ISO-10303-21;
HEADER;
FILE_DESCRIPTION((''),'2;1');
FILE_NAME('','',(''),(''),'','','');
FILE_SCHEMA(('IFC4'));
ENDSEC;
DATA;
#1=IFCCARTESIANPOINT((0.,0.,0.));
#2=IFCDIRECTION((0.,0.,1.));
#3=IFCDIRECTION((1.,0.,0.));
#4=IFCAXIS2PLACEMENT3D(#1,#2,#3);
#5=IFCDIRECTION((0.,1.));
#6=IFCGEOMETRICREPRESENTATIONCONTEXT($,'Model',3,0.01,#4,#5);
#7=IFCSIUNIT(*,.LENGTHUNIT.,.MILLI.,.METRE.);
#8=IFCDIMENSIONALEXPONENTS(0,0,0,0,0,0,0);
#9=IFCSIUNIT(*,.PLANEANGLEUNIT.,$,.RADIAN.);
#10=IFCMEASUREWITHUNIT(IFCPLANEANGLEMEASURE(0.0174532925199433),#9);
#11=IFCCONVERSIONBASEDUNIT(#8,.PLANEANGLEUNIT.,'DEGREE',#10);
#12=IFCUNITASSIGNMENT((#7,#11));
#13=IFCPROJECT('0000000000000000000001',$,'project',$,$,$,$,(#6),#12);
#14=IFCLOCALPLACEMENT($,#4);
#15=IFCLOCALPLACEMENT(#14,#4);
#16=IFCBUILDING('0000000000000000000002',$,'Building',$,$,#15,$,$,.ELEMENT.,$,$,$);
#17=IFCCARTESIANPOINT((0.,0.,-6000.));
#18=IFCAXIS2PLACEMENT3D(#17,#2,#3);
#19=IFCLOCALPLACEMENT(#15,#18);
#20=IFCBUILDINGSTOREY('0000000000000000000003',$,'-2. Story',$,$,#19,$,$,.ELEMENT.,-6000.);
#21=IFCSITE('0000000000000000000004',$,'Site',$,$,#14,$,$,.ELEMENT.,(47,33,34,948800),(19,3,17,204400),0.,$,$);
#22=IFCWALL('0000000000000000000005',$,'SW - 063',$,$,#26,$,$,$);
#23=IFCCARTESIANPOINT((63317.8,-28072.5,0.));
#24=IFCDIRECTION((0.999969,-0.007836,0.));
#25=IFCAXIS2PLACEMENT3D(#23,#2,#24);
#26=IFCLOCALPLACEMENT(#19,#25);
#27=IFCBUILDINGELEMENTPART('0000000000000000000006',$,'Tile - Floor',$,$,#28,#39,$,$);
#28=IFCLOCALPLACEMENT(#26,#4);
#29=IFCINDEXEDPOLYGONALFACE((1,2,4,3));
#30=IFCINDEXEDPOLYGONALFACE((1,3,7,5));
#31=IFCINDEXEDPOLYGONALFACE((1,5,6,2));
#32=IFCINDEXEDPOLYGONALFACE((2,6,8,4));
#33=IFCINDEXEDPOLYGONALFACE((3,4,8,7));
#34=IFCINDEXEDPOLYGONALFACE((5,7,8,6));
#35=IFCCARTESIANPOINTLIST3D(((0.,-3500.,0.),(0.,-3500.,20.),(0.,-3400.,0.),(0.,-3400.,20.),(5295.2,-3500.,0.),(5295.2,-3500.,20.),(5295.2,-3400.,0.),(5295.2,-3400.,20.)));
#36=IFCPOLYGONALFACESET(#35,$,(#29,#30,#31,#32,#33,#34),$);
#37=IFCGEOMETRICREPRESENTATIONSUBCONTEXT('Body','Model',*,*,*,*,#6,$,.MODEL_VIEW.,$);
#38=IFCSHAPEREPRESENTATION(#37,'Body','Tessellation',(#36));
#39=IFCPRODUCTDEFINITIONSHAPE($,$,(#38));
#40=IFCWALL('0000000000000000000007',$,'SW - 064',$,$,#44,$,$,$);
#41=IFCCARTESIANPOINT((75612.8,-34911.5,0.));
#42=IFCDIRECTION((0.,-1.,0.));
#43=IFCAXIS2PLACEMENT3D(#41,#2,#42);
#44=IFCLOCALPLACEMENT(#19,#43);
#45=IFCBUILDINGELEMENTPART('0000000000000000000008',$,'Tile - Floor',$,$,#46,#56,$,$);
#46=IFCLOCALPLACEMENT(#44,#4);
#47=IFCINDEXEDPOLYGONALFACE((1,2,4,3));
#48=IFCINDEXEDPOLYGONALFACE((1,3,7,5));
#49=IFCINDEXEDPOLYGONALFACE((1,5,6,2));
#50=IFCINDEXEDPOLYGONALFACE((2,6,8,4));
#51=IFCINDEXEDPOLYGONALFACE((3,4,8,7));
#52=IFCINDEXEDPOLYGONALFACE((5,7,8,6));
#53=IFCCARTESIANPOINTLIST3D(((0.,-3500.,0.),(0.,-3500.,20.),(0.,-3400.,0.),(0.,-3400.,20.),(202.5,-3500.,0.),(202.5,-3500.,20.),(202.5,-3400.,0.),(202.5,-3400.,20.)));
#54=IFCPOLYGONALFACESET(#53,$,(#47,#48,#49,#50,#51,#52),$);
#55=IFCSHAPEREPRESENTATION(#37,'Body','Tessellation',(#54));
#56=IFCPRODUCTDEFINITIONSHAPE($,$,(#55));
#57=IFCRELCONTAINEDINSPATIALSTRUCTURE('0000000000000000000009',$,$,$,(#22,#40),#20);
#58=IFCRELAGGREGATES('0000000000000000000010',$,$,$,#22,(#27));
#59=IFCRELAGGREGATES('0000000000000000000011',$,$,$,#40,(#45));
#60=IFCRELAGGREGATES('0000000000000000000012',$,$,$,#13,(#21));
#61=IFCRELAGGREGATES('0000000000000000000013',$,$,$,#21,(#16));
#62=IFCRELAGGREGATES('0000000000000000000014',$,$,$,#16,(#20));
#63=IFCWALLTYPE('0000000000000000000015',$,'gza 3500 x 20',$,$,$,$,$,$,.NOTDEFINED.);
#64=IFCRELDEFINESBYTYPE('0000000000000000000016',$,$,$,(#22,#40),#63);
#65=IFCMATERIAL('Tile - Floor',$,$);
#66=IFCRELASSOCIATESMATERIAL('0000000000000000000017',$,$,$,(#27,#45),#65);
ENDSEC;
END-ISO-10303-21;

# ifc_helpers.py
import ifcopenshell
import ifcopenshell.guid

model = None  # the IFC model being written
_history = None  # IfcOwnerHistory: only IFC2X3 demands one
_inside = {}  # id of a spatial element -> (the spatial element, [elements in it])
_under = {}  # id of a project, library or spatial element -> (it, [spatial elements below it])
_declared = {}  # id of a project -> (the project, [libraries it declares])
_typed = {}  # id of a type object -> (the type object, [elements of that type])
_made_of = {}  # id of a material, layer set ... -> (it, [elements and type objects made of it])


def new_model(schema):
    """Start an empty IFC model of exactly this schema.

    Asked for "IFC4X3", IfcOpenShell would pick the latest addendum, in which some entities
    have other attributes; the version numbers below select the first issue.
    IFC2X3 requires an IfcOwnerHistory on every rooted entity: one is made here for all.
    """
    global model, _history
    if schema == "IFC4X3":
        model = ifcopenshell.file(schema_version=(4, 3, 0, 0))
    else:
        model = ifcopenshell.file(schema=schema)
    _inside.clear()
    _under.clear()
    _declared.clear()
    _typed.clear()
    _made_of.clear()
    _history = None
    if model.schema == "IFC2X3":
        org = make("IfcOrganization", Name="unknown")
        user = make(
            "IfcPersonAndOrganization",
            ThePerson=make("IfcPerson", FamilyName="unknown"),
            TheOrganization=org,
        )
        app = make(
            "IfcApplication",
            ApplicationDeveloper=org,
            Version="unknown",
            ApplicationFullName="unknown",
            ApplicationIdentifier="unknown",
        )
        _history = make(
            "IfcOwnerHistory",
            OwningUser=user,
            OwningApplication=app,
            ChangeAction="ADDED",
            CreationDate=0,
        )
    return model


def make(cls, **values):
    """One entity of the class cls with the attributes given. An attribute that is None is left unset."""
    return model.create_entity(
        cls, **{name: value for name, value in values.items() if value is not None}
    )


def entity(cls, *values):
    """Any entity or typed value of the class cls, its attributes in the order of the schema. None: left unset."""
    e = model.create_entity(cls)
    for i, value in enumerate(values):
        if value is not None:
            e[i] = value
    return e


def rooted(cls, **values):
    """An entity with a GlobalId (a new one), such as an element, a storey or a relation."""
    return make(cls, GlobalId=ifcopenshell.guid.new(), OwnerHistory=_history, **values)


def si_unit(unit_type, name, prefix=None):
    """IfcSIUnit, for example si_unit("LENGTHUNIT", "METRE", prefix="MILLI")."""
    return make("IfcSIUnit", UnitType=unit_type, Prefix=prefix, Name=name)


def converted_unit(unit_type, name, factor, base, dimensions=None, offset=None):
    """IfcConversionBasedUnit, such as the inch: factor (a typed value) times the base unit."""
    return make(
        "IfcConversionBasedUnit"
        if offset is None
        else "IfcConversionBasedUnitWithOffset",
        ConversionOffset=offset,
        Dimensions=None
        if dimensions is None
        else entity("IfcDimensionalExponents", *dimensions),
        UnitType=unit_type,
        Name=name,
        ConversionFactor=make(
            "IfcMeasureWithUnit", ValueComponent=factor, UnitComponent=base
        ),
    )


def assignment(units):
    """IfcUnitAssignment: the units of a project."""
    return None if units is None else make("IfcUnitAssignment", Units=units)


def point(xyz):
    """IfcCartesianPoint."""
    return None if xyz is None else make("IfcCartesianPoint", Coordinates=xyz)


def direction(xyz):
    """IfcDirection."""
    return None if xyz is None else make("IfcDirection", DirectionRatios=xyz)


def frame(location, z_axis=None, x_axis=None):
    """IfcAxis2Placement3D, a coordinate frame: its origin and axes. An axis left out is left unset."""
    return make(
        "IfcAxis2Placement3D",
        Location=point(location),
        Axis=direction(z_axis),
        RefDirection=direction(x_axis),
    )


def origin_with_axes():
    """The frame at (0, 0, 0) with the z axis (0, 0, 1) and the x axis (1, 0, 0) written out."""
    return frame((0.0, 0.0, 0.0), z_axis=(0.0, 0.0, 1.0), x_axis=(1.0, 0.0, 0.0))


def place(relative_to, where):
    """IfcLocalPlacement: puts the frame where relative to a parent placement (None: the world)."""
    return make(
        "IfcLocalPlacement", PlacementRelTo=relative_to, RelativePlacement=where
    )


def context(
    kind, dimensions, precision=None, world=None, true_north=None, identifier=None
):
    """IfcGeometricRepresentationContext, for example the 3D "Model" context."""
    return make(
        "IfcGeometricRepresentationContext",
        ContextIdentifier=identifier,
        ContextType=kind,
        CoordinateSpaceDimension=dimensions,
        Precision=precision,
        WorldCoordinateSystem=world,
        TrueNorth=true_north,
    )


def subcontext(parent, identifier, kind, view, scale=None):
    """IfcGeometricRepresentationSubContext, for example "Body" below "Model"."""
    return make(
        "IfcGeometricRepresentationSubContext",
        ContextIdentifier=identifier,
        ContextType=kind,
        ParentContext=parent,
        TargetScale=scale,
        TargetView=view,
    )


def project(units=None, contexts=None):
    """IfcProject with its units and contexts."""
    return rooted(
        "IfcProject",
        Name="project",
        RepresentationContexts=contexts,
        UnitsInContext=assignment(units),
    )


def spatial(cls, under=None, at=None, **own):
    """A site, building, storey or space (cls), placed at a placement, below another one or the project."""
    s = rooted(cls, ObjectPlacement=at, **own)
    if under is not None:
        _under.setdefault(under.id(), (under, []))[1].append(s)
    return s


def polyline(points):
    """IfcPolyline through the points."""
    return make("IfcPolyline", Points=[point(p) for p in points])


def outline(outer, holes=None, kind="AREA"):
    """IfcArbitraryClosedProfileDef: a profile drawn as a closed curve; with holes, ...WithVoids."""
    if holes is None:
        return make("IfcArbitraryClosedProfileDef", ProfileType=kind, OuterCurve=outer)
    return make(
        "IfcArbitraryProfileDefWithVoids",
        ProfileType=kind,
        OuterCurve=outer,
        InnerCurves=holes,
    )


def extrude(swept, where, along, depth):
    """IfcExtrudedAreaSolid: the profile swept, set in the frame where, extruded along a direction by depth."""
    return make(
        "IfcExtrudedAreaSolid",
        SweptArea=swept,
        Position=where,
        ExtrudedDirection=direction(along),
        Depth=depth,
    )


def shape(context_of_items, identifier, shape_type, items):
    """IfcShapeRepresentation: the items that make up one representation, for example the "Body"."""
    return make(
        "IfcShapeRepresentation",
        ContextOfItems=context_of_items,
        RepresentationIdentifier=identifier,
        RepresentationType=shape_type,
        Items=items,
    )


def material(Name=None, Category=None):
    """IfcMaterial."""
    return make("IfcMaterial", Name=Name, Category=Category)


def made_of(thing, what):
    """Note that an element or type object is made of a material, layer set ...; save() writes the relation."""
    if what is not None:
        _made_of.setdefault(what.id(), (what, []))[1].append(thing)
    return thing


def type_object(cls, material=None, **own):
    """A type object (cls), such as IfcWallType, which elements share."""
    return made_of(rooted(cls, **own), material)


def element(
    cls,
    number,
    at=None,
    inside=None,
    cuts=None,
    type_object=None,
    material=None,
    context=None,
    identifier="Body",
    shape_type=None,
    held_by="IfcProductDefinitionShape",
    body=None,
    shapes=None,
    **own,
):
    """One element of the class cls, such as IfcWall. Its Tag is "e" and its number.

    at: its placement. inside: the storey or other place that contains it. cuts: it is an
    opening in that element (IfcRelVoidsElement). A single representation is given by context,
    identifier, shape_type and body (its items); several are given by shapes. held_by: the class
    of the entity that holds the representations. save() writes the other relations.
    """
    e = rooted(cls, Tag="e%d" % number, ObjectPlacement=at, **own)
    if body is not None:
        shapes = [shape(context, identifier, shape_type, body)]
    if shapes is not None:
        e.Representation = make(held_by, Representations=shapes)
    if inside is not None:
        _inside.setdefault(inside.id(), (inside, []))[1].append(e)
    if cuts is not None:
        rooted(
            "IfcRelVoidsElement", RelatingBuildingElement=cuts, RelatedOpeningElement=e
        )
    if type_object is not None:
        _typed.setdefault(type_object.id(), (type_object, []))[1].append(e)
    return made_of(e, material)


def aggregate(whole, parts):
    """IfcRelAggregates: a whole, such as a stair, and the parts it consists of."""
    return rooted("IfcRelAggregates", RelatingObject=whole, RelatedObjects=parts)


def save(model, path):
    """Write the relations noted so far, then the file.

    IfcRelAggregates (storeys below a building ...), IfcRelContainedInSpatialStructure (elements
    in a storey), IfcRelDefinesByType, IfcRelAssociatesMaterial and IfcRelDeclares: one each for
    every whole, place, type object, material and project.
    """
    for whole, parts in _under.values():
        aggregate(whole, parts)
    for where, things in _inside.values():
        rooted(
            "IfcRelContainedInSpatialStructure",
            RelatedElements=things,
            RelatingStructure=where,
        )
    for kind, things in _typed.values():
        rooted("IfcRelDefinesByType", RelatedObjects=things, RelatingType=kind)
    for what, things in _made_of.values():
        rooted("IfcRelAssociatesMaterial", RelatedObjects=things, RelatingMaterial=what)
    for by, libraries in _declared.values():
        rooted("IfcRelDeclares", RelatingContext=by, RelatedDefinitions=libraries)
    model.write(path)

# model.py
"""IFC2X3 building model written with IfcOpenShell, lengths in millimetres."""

from ifc_helpers import new_model, entity, si_unit, converted_unit, direction, frame, origin_with_axes, place, context, subcontext, project, spatial, polyline, outline, extrude, material, type_object, element, aggregate, save


model = new_model("IFC2X3")

# Units and contexts
model_context = context("Model", 3, precision=0.01, world=origin_with_axes(), true_north=direction((0.0, 1.0)))
body_context = subcontext(model_context, "Body", "Model", "MODEL_VIEW")
ifc_project = project(units=[si_unit("LENGTHUNIT", "METRE", prefix="MILLI"), converted_unit("PLANEANGLEUNIT", "DEGREE", entity("IfcPlaneAngleMeasure", 0.0174532925199433), si_unit("PLANEANGLEUNIT", "RADIAN"), dimensions=[0, 0, 0, 0, 0, 0, 0])], contexts=[model_context])

# Site, building, storey
site_placement = place(None, origin_with_axes())
site = spatial("IfcSite", under=ifc_project, at=site_placement, Name="Site", CompositionType="ELEMENT", RefLatitude=(47, 33, 34, 948800), RefLongitude=(19, 3, 17, 204400), RefElevation=0.0)
building_placement = place(site_placement, origin_with_axes())
building = spatial("IfcBuilding", under=site, at=building_placement, Name="Building", CompositionType="ELEMENT")
storey_placement = place(building_placement, frame((0.0, 0.0, -6000.0), z_axis=(0.0, 0.0, 1.0), x_axis=(1.0, 0.0, 0.0)))
storey = spatial("IfcBuildingStorey", under=building, at=storey_placement, Name="-2. Story", CompositionType="ELEMENT", Elevation=-6000.0)

# Walls, building element parts
wall_type_1 = type_object("IfcWallType", Name="gza 3500 x 20", PredefinedType="NOTDEFINED")
wall_1_placement = place(storey_placement, frame((63317.8, -28072.5, 0.0), z_axis=(0.0, 0.0, 1.0), x_axis=(0.999969, -0.007836, 0.0)))
wall_1 = element("IfcWall", 1, at=wall_1_placement, inside=storey, type_object=wall_type_1, Name="SW - 063")
ifc_material_1 = material(Name="Tile - Floor")
building_element_part_1_placement = place(wall_1_placement, origin_with_axes())
building_element_part_1 = element("IfcBuildingElementPart", 2, at=building_element_part_1_placement, material=ifc_material_1, Name="Tile - Floor", context=body_context, shape_type="SweptSolid", body=[
    extrude(outline(polyline([(3400.0, 20.0), (3400.0, 0.0), (3500.0, 0.0), (3500.0, 20.0), (3400.0, 20.0)])), frame((0.0, 0.0, 0.0), z_axis=(-1.0, 0.0, 0.0), x_axis=(0.0, -1.0, 0.0)), (0.0, 0.0, -1.0), 5295.2),
])
aggregate(wall_1, [building_element_part_1])
wall_2_placement = place(storey_placement, frame((75612.8, -34911.5, 0.0), z_axis=(0.0, 0.0, 1.0), x_axis=(0.0, -1.0, 0.0)))
wall_2 = element("IfcWall", 3, at=wall_2_placement, inside=storey, type_object=wall_type_1, Name="SW - 064")
building_element_part_2_placement = place(wall_2_placement, origin_with_axes())
building_element_part_2 = element("IfcBuildingElementPart", 4, at=building_element_part_2_placement, material=ifc_material_1, Name="Tile - Floor", context=body_context, shape_type="SweptSolid", body=[
    extrude(outline(polyline([(3400.0, 20.0), (3400.0, 0.0), (3500.0, 0.0), (3500.0, 20.0), (3400.0, 20.0)])), frame((0.0, 0.0, 0.0), z_axis=(-1.0, 0.0, 0.0), x_axis=(0.0, -1.0, 0.0)), (0.0, 0.0, -1.0), 202.5),
])
aggregate(wall_2, [building_element_part_2])

save(model, "model.ifc")
